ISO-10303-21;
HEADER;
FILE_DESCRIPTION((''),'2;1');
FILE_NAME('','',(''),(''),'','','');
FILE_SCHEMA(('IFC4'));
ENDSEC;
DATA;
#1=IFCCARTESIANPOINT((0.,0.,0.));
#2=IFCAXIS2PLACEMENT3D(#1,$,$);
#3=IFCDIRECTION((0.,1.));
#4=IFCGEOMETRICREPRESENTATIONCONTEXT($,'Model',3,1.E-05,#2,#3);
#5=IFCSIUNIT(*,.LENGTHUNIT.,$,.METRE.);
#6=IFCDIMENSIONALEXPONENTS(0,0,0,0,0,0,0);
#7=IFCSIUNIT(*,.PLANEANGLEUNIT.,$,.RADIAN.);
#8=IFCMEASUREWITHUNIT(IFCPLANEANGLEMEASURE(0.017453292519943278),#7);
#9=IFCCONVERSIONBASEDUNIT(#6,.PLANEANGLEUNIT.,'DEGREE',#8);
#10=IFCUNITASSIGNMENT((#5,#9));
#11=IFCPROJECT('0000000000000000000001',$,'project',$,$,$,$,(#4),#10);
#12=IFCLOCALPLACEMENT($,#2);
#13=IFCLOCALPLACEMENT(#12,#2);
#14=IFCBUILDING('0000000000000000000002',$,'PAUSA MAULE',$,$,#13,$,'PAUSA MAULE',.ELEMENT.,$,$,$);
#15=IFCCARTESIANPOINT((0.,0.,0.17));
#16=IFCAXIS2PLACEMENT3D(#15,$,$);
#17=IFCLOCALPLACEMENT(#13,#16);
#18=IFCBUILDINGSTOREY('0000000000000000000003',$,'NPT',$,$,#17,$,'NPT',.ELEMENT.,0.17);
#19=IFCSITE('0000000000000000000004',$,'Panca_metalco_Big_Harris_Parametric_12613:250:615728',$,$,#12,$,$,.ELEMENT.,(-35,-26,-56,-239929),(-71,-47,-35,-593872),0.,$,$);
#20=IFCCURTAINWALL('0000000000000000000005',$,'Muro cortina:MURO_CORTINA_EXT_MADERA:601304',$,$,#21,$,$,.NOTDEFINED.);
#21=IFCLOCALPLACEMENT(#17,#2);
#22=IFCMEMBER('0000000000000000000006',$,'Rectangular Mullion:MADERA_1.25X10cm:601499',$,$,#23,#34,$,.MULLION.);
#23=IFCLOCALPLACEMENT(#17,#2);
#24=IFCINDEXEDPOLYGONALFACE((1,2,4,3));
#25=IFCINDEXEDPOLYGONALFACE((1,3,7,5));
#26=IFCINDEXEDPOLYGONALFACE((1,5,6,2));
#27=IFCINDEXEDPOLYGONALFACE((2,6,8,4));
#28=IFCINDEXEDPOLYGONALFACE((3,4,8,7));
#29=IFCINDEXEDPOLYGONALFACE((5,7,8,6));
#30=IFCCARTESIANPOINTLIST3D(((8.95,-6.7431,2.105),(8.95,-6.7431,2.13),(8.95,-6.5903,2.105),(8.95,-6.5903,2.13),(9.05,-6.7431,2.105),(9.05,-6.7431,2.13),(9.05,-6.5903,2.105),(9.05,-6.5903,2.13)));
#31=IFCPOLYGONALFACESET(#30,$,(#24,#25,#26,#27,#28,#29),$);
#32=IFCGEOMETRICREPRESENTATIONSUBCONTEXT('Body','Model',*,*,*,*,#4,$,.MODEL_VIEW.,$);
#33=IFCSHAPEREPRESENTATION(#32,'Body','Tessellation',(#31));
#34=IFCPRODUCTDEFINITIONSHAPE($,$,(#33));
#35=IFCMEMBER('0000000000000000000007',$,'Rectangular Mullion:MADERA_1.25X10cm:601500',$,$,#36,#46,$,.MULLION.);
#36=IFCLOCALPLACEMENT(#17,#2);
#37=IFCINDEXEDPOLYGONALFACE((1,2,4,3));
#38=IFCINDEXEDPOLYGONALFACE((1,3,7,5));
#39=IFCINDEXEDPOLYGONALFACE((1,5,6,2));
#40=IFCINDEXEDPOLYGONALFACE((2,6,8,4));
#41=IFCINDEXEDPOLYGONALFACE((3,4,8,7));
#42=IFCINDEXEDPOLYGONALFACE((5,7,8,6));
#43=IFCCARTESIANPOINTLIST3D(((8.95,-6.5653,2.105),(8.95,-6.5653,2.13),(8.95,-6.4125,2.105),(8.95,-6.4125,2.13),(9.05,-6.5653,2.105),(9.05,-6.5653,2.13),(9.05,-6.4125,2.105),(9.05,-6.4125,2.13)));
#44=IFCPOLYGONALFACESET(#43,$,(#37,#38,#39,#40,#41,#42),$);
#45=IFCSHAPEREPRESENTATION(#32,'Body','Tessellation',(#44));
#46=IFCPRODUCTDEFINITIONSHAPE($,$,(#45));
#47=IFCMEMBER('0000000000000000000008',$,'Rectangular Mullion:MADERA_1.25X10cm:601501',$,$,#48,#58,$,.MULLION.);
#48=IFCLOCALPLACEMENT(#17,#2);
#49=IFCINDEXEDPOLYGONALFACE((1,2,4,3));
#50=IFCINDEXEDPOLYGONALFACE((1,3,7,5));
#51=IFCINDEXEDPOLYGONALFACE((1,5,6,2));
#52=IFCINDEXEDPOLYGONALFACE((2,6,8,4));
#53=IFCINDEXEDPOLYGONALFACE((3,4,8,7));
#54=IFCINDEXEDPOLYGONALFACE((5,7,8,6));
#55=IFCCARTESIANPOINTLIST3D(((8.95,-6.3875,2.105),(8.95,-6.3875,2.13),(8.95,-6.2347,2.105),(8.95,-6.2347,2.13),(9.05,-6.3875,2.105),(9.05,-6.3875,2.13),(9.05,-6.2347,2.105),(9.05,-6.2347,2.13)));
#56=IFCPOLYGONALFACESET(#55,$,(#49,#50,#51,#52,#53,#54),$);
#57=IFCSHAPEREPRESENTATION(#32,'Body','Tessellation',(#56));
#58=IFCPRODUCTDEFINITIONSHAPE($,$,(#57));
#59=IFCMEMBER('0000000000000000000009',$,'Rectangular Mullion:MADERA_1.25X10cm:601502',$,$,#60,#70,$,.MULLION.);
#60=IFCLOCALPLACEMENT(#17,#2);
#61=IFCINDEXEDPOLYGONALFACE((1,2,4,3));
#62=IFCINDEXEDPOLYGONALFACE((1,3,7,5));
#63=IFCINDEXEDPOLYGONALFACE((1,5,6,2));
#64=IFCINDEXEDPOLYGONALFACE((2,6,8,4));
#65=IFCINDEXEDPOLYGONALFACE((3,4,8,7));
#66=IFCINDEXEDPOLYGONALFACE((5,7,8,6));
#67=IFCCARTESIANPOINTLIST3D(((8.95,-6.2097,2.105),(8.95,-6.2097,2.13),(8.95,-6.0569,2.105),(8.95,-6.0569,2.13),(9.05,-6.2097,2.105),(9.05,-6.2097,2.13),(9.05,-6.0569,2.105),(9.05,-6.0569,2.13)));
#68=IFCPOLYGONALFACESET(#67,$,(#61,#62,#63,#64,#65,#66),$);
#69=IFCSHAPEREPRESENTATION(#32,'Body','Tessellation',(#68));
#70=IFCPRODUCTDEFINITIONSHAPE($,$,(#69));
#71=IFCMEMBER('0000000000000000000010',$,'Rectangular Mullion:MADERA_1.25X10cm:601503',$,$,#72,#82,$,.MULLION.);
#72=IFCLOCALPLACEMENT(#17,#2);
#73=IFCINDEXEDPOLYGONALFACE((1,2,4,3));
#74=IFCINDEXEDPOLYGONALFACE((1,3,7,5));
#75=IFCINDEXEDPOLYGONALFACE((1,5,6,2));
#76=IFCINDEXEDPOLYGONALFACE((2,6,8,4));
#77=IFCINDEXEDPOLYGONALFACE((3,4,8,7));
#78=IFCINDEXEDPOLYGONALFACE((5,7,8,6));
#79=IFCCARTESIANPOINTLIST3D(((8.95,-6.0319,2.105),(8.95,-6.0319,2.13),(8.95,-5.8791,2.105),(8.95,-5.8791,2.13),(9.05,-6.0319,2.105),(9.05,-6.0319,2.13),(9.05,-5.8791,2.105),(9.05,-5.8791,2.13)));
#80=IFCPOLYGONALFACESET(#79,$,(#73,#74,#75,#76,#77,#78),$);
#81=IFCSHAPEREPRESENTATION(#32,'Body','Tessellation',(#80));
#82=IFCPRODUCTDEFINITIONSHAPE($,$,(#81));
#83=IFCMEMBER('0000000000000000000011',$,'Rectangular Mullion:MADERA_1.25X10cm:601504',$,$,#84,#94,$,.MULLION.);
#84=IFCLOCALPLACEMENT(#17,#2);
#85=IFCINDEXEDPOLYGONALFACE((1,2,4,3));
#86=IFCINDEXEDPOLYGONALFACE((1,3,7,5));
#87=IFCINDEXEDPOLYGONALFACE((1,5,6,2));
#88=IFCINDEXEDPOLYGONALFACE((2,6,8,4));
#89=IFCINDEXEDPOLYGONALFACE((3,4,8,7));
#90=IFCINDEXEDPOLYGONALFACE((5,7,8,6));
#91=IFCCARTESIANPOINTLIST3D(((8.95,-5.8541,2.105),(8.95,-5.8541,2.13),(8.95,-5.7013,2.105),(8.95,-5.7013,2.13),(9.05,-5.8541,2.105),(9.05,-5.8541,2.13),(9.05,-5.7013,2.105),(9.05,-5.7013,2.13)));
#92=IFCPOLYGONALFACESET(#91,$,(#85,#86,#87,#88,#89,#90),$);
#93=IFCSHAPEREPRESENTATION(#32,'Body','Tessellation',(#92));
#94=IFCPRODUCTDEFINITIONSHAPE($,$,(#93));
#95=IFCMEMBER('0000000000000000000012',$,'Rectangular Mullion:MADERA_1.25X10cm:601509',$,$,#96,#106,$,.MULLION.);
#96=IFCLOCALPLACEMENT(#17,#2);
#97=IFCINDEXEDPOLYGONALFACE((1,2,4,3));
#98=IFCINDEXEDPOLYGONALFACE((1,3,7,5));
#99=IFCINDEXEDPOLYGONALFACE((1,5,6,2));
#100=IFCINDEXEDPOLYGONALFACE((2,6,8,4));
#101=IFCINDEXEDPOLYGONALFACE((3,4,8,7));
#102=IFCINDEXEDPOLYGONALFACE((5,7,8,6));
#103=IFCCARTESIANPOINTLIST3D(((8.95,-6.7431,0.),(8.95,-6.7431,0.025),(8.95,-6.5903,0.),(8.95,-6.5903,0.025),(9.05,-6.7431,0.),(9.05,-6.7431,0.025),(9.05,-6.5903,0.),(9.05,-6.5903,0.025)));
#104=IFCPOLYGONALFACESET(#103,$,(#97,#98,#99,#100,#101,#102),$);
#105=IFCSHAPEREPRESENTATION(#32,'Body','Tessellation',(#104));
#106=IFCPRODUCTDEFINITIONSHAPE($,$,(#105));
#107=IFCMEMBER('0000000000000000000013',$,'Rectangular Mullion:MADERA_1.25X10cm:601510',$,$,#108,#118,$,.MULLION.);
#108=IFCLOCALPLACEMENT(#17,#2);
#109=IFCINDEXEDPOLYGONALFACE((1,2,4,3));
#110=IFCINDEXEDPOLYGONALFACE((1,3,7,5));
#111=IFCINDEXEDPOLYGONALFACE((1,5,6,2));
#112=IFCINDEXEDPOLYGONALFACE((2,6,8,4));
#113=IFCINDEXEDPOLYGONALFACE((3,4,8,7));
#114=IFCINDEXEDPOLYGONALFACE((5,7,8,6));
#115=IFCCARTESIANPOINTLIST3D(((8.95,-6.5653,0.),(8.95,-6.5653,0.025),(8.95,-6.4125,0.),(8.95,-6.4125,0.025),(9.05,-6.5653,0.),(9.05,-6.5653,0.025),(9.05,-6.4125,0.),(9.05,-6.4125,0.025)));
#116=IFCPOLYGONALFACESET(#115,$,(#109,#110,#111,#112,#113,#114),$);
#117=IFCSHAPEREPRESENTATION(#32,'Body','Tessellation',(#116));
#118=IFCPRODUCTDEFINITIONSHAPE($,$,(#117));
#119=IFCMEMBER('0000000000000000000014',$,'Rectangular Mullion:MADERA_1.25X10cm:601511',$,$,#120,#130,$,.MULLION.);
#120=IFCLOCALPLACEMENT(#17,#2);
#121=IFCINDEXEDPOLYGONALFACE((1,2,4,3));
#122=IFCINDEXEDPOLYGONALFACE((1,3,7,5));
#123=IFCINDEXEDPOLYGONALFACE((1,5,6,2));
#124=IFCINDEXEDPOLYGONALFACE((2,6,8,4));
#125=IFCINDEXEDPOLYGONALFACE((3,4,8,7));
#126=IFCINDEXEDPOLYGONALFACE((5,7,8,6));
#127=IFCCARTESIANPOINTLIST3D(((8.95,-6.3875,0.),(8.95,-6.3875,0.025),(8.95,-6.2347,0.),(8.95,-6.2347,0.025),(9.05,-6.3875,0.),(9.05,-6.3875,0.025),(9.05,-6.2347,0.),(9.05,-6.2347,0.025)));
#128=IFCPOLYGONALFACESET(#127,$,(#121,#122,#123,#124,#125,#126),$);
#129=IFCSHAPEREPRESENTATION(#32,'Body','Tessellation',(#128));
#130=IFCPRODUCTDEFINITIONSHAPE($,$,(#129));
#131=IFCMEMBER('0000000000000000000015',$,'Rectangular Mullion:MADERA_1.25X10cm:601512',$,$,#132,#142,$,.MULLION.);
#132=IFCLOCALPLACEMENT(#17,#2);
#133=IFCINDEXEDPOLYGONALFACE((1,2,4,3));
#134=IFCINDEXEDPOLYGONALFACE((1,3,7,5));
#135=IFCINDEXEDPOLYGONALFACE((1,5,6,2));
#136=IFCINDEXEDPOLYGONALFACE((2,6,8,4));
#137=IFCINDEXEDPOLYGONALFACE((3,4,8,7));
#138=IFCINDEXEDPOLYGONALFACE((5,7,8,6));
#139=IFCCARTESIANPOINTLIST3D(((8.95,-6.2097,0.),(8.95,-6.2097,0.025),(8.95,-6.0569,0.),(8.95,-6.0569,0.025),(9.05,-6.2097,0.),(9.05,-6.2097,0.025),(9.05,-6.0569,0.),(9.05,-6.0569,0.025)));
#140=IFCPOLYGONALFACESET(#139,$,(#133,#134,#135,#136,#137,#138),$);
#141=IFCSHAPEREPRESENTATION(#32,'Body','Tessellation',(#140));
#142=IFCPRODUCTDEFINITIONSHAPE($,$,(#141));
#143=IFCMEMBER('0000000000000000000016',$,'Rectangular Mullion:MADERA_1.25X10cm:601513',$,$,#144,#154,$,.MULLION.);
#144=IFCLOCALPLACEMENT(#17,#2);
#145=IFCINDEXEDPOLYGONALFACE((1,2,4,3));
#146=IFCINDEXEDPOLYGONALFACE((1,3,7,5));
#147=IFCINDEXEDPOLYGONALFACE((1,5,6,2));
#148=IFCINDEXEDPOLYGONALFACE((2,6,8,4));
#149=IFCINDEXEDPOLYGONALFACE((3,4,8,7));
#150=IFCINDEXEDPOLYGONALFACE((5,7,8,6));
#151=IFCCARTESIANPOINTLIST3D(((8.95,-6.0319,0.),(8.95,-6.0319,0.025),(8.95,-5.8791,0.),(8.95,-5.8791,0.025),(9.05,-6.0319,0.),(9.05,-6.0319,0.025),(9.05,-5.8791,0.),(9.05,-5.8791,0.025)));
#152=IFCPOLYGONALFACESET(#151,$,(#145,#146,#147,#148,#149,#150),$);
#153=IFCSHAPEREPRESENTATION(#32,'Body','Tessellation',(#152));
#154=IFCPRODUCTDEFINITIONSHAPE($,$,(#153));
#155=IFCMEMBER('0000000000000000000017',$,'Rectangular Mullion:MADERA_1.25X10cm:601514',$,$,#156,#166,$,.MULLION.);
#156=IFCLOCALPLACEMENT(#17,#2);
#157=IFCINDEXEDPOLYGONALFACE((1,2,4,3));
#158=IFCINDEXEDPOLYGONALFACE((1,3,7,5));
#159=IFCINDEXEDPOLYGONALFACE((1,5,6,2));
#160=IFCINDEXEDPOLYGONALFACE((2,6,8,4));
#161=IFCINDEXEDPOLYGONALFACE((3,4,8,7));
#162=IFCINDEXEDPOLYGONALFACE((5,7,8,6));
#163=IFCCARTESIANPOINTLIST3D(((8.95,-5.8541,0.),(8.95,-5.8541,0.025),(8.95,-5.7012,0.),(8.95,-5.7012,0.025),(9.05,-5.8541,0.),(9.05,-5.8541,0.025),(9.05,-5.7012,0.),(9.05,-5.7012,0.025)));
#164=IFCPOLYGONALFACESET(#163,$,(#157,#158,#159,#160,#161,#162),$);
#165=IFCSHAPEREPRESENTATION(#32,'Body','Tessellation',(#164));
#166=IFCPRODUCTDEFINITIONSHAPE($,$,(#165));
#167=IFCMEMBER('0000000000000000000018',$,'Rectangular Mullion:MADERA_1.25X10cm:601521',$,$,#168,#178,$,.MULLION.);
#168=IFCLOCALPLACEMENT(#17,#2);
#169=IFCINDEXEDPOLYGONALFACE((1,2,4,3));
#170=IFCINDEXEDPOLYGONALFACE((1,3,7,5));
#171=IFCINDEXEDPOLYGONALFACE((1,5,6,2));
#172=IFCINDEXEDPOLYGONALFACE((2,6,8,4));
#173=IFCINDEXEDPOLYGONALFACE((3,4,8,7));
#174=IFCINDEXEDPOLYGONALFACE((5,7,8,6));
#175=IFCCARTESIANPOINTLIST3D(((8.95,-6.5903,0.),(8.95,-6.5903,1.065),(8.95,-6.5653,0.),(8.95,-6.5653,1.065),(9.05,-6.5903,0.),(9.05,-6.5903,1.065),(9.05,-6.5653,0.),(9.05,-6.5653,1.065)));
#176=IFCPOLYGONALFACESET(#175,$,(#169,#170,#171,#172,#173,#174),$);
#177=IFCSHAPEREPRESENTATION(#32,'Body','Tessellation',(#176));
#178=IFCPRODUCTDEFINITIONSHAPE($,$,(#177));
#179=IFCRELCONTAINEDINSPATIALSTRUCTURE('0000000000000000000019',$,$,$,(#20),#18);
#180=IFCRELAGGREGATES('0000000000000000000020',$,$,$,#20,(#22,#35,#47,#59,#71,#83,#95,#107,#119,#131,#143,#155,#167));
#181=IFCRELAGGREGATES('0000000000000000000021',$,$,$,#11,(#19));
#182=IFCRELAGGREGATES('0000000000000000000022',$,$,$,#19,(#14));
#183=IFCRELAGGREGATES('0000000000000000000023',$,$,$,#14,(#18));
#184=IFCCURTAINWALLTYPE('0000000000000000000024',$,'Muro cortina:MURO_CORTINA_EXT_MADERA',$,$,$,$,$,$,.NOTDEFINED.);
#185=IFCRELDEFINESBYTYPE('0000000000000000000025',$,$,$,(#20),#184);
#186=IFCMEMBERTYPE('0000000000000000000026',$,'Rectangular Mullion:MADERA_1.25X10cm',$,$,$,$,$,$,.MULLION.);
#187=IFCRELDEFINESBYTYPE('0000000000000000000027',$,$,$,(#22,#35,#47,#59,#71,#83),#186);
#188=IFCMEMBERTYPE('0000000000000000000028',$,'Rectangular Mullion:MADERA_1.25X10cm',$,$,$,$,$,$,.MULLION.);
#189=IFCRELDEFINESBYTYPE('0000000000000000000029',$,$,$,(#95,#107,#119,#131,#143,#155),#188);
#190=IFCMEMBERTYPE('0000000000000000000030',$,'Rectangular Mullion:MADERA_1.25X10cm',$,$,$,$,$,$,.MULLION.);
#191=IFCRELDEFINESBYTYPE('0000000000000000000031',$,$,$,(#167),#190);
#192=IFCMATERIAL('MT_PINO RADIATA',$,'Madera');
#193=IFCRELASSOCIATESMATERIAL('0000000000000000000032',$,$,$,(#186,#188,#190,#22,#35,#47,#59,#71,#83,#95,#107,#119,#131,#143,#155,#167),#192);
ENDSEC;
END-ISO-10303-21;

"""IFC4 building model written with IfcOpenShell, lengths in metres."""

from ifc_helpers import new_model, entity, si_unit, converted_unit, direction, frame, frame_2d, origin, place, context, subcontext, project, spatial, rectangle, extrude, source, transform, mapped, material, material_profile, profile_set, profile_usage, type_object, type_shapes, element, aggregate, save


model = new_model("IFC4")

# Units and contexts
model_context = context("Model", 3, precision=1e-05, world=origin(), true_north=direction((0.0, 1.0)))
body_context = subcontext(model_context, "Body", "Model", "MODEL_VIEW")
ifc_project = project(units=[si_unit("LENGTHUNIT", "METRE"), converted_unit("PLANEANGLEUNIT", "DEGREE", entity("IfcPlaneAngleMeasure", 0.017453292519943278), si_unit("PLANEANGLEUNIT", "RADIAN"), dimensions=[0, 0, 0, 0, 0, 0, 0])], contexts=[model_context])

# Site, building, storey
site_placement = place(None, origin())
site = spatial("IfcSite", under=ifc_project, at=site_placement, Name="Panca_metalco_Big_Harris_Parametric_12613:250:615728", CompositionType="ELEMENT", RefLatitude=(-35, -26, -56, -239929), RefLongitude=(-71, -47, -35, -593872), RefElevation=0.0)
building_placement = place(site_placement, origin())
building = spatial("IfcBuilding", under=site, at=building_placement, Name="PAUSA MAULE", LongName="PAUSA MAULE", CompositionType="ELEMENT")
storey_placement = place(building_placement, frame((0.0, 0.0, 0.17)))
storey = spatial("IfcBuildingStorey", under=building, at=storey_placement, Name="NPT", LongName="NPT", CompositionType="ELEMENT", Elevation=0.17)

# Curtain wall, members
curtain_wall_type = type_object("IfcCurtainWallType", Name="Muro cortina:MURO_CORTINA_EXT_MADERA", PredefinedType="NOTDEFINED")
curtain_wall_placement = place(storey_placement, frame((0.0, 0.0, -0.17)))
curtain_wall = element("IfcCurtainWall", 1, at=curtain_wall_placement, inside=storey, type_object=curtain_wall_type, Name="Muro cortina:MURO_CORTINA_EXT_MADERA:601304", PredefinedType="NOTDEFINED")
ifc_material = material(Name="MT_PINO RADIATA", Category="Madera")
ifc_material_profile = material_profile(ifc_material, rectangle(XDim=0.025, YDim=0.1, at=frame_2d((0.0, 0.0), x_axis=(1.0, 0.0))), Name="MADERA_1.25X10cm")
ifc_profile_set = profile_set([ifc_material_profile], Name="MADERA_1.25X10cm")
ifc_profile_usage = profile_usage(ifc_profile_set)
member_type_1 = type_object("IfcMemberType", Name="Rectangular Mullion:MADERA_1.25X10cm", PredefinedType="MULLION", material=ifc_profile_set)
shared_shape_1 = source(origin(), body_context, "Body", "SweptSolid", [
    extrude(rectangle(XDim=0.025, YDim=0.1, at=frame_2d((0.0, 0.0), x_axis=(1.0, 0.0))), frame((-0.0125, 0.0, -0.1528), z_axis=(0.0, 0.0, 1.0), x_axis=(-1.0, 0.0, 0.0)), (0.0, 0.0, 1.0), 0.1528),
])
type_shapes(member_type_1, [shared_shape_1])
member_1_placement = place(curtain_wall_placement, frame((9.0, -6.5903, 2.3), z_axis=(0.0, 1.0, 0.0), x_axis=(0.0, 0.0, 1.0)))
member_1 = element("IfcMember", 2, at=member_1_placement, type_object=member_type_1, material=ifc_profile_usage, Name="Rectangular Mullion:MADERA_1.25X10cm:601499", PredefinedType="MULLION", context=body_context, shape_type="MappedRepresentation", body=[
    mapped(shared_shape_1, transform((0.0, 0.0, 0.0), scale=1.0)),
])
member_2_placement = place(curtain_wall_placement, frame((9.0, -6.4125, 2.3), z_axis=(0.0, 1.0, 0.0), x_axis=(0.0, 0.0, 1.0)))
member_2 = element("IfcMember", 3, at=member_2_placement, type_object=member_type_1, material=ifc_profile_usage, Name="Rectangular Mullion:MADERA_1.25X10cm:601500", PredefinedType="MULLION", context=body_context, shape_type="MappedRepresentation", body=[
    mapped(shared_shape_1, transform((0.0, 0.0, 0.0), scale=1.0)),
])
member_3_placement = place(curtain_wall_placement, frame((9.0, -6.2347, 2.3), z_axis=(0.0, 1.0, 0.0), x_axis=(0.0, 0.0, 1.0)))
member_3 = element("IfcMember", 4, at=member_3_placement, type_object=member_type_1, material=ifc_profile_usage, Name="Rectangular Mullion:MADERA_1.25X10cm:601501", PredefinedType="MULLION", context=body_context, shape_type="MappedRepresentation", body=[
    mapped(shared_shape_1, transform((0.0, 0.0, 0.0), scale=1.0)),
])
member_4_placement = place(curtain_wall_placement, frame((9.0, -6.0569, 2.3), z_axis=(0.0, 1.0, 0.0), x_axis=(0.0, 0.0, 1.0)))
member_4 = element("IfcMember", 5, at=member_4_placement, type_object=member_type_1, material=ifc_profile_usage, Name="Rectangular Mullion:MADERA_1.25X10cm:601502", PredefinedType="MULLION", context=body_context, shape_type="MappedRepresentation", body=[
    mapped(shared_shape_1, transform((0.0, 0.0, 0.0), scale=1.0)),
])
member_5_placement = place(curtain_wall_placement, frame((9.0, -5.8791, 2.3), z_axis=(0.0, 1.0, 0.0), x_axis=(0.0, 0.0, 1.0)))
member_5 = element("IfcMember", 6, at=member_5_placement, type_object=member_type_1, material=ifc_profile_usage, Name="Rectangular Mullion:MADERA_1.25X10cm:601503", PredefinedType="MULLION", context=body_context, shape_type="MappedRepresentation", body=[
    mapped(shared_shape_1, transform((0.0, 0.0, 0.0), scale=1.0)),
])
member_6_placement = place(curtain_wall_placement, frame((9.0, -5.7013, 2.3), z_axis=(0.0, 1.0, 0.0), x_axis=(0.0, 0.0, 1.0)))
member_6 = element("IfcMember", 7, at=member_6_placement, type_object=member_type_1, material=ifc_profile_usage, Name="Rectangular Mullion:MADERA_1.25X10cm:601504", PredefinedType="MULLION", context=body_context, shape_type="MappedRepresentation", body=[
    mapped(shared_shape_1, transform((0.0, 0.0, 0.0), scale=1.0)),
])
member_type_2 = type_object("IfcMemberType", Name="Rectangular Mullion:MADERA_1.25X10cm", PredefinedType="MULLION", material=ifc_profile_set)
shared_shape_2 = source(origin(), body_context, "Body", "SweptSolid", [
    extrude(rectangle(XDim=0.025, YDim=0.1, at=frame_2d((0.0, 0.0), x_axis=(1.0, 0.0))), frame((-0.0125, 0.0, -0.1528), z_axis=(0.0, 0.0, 1.0), x_axis=(-1.0, 0.0, 0.0)), (0.0, 0.0, 1.0), 0.1528),
])
type_shapes(member_type_2, [shared_shape_2])
member_7_placement = place(curtain_wall_placement, frame((9.0, -6.7431, 0.17), z_axis=(0.0, -1.0, 0.0), x_axis=(0.0, 0.0, -1.0)))
member_7 = element("IfcMember", 8, at=member_7_placement, type_object=member_type_2, material=ifc_profile_usage, Name="Rectangular Mullion:MADERA_1.25X10cm:601509", PredefinedType="MULLION", context=body_context, shape_type="MappedRepresentation", body=[
    mapped(shared_shape_2, transform((0.0, 0.0, 0.0), scale=1.0)),
])
member_8_placement = place(curtain_wall_placement, frame((9.0, -6.5653, 0.17), z_axis=(0.0, -1.0, 0.0), x_axis=(0.0, 0.0, -1.0)))
member_8 = element("IfcMember", 9, at=member_8_placement, type_object=member_type_2, material=ifc_profile_usage, Name="Rectangular Mullion:MADERA_1.25X10cm:601510", PredefinedType="MULLION", context=body_context, shape_type="MappedRepresentation", body=[
    mapped(shared_shape_2, transform((0.0, 0.0, 0.0), scale=1.0)),
])
member_9_placement = place(curtain_wall_placement, frame((9.0, -6.3875, 0.17), z_axis=(0.0, -1.0, 0.0), x_axis=(0.0, 0.0, -1.0)))
member_9 = element("IfcMember", 10, at=member_9_placement, type_object=member_type_2, material=ifc_profile_usage, Name="Rectangular Mullion:MADERA_1.25X10cm:601511", PredefinedType="MULLION", context=body_context, shape_type="MappedRepresentation", body=[
    mapped(shared_shape_2, transform((0.0, 0.0, 0.0), scale=1.0)),
])
member_10_placement = place(curtain_wall_placement, frame((9.0, -6.2097, 0.17), z_axis=(0.0, -1.0, 0.0), x_axis=(0.0, 0.0, -1.0)))
member_10 = element("IfcMember", 11, at=member_10_placement, type_object=member_type_2, material=ifc_profile_usage, Name="Rectangular Mullion:MADERA_1.25X10cm:601512", PredefinedType="MULLION", context=body_context, shape_type="MappedRepresentation", body=[
    mapped(shared_shape_2, transform((0.0, 0.0, 0.0), scale=1.0)),
])
member_11_placement = place(curtain_wall_placement, frame((9.0, -6.0319, 0.17), z_axis=(0.0, -1.0, 0.0), x_axis=(0.0, 0.0, -1.0)))
member_11 = element("IfcMember", 12, at=member_11_placement, type_object=member_type_2, material=ifc_profile_usage, Name="Rectangular Mullion:MADERA_1.25X10cm:601513", PredefinedType="MULLION", context=body_context, shape_type="MappedRepresentation", body=[
    mapped(shared_shape_2, transform((0.0, 0.0, 0.0), scale=1.0)),
])
member_12_placement = place(curtain_wall_placement, frame((9.0, -5.8541, 0.17), z_axis=(0.0, -1.0, 0.0), x_axis=(0.0, 0.0, -1.0)))
member_12 = element("IfcMember", 13, at=member_12_placement, type_object=member_type_2, material=ifc_profile_usage, Name="Rectangular Mullion:MADERA_1.25X10cm:601514", PredefinedType="MULLION", context=body_context, shape_type="MappedRepresentation", body=[
    mapped(shared_shape_2, transform((0.0, 0.0, 0.0), scale=1.0)),
])
member_type_3 = type_object("IfcMemberType", Name="Rectangular Mullion:MADERA_1.25X10cm", PredefinedType="MULLION", material=ifc_profile_set)
shared_shape_3 = source(origin(), body_context, "Body", "SweptSolid", [
    extrude(rectangle(XDim=0.025, YDim=0.1, at=frame_2d((0.0, 0.0), x_axis=(1.0, 0.0))), frame((0.0, 0.0, -1.065), z_axis=(0.0, 0.0, 1.0), x_axis=(-1.0, 0.0, 0.0)), (0.0, 0.0, 1.0), 1.065),
])
type_shapes(member_type_3, [shared_shape_3])
member_13_placement = place(curtain_wall_placement, frame((9.0, -6.5778, 0.17), z_axis=(0.0, 0.0, -1.0), x_axis=(0.0, 1.0, 0.0)))
member_13 = element("IfcMember", 14, at=member_13_placement, type_object=member_type_3, material=ifc_profile_usage, Name="Rectangular Mullion:MADERA_1.25X10cm:601521", PredefinedType="MULLION", context=body_context, shape_type="MappedRepresentation", body=[
    mapped(shared_shape_3, transform((0.0, 0.0, 0.0), scale=1.0)),
])
aggregate(curtain_wall, [member_1, member_2, member_3, member_4, member_5, member_6, member_7, member_8, member_9, member_10, member_11, member_12, member_13])

save(model, "model.ifc")
